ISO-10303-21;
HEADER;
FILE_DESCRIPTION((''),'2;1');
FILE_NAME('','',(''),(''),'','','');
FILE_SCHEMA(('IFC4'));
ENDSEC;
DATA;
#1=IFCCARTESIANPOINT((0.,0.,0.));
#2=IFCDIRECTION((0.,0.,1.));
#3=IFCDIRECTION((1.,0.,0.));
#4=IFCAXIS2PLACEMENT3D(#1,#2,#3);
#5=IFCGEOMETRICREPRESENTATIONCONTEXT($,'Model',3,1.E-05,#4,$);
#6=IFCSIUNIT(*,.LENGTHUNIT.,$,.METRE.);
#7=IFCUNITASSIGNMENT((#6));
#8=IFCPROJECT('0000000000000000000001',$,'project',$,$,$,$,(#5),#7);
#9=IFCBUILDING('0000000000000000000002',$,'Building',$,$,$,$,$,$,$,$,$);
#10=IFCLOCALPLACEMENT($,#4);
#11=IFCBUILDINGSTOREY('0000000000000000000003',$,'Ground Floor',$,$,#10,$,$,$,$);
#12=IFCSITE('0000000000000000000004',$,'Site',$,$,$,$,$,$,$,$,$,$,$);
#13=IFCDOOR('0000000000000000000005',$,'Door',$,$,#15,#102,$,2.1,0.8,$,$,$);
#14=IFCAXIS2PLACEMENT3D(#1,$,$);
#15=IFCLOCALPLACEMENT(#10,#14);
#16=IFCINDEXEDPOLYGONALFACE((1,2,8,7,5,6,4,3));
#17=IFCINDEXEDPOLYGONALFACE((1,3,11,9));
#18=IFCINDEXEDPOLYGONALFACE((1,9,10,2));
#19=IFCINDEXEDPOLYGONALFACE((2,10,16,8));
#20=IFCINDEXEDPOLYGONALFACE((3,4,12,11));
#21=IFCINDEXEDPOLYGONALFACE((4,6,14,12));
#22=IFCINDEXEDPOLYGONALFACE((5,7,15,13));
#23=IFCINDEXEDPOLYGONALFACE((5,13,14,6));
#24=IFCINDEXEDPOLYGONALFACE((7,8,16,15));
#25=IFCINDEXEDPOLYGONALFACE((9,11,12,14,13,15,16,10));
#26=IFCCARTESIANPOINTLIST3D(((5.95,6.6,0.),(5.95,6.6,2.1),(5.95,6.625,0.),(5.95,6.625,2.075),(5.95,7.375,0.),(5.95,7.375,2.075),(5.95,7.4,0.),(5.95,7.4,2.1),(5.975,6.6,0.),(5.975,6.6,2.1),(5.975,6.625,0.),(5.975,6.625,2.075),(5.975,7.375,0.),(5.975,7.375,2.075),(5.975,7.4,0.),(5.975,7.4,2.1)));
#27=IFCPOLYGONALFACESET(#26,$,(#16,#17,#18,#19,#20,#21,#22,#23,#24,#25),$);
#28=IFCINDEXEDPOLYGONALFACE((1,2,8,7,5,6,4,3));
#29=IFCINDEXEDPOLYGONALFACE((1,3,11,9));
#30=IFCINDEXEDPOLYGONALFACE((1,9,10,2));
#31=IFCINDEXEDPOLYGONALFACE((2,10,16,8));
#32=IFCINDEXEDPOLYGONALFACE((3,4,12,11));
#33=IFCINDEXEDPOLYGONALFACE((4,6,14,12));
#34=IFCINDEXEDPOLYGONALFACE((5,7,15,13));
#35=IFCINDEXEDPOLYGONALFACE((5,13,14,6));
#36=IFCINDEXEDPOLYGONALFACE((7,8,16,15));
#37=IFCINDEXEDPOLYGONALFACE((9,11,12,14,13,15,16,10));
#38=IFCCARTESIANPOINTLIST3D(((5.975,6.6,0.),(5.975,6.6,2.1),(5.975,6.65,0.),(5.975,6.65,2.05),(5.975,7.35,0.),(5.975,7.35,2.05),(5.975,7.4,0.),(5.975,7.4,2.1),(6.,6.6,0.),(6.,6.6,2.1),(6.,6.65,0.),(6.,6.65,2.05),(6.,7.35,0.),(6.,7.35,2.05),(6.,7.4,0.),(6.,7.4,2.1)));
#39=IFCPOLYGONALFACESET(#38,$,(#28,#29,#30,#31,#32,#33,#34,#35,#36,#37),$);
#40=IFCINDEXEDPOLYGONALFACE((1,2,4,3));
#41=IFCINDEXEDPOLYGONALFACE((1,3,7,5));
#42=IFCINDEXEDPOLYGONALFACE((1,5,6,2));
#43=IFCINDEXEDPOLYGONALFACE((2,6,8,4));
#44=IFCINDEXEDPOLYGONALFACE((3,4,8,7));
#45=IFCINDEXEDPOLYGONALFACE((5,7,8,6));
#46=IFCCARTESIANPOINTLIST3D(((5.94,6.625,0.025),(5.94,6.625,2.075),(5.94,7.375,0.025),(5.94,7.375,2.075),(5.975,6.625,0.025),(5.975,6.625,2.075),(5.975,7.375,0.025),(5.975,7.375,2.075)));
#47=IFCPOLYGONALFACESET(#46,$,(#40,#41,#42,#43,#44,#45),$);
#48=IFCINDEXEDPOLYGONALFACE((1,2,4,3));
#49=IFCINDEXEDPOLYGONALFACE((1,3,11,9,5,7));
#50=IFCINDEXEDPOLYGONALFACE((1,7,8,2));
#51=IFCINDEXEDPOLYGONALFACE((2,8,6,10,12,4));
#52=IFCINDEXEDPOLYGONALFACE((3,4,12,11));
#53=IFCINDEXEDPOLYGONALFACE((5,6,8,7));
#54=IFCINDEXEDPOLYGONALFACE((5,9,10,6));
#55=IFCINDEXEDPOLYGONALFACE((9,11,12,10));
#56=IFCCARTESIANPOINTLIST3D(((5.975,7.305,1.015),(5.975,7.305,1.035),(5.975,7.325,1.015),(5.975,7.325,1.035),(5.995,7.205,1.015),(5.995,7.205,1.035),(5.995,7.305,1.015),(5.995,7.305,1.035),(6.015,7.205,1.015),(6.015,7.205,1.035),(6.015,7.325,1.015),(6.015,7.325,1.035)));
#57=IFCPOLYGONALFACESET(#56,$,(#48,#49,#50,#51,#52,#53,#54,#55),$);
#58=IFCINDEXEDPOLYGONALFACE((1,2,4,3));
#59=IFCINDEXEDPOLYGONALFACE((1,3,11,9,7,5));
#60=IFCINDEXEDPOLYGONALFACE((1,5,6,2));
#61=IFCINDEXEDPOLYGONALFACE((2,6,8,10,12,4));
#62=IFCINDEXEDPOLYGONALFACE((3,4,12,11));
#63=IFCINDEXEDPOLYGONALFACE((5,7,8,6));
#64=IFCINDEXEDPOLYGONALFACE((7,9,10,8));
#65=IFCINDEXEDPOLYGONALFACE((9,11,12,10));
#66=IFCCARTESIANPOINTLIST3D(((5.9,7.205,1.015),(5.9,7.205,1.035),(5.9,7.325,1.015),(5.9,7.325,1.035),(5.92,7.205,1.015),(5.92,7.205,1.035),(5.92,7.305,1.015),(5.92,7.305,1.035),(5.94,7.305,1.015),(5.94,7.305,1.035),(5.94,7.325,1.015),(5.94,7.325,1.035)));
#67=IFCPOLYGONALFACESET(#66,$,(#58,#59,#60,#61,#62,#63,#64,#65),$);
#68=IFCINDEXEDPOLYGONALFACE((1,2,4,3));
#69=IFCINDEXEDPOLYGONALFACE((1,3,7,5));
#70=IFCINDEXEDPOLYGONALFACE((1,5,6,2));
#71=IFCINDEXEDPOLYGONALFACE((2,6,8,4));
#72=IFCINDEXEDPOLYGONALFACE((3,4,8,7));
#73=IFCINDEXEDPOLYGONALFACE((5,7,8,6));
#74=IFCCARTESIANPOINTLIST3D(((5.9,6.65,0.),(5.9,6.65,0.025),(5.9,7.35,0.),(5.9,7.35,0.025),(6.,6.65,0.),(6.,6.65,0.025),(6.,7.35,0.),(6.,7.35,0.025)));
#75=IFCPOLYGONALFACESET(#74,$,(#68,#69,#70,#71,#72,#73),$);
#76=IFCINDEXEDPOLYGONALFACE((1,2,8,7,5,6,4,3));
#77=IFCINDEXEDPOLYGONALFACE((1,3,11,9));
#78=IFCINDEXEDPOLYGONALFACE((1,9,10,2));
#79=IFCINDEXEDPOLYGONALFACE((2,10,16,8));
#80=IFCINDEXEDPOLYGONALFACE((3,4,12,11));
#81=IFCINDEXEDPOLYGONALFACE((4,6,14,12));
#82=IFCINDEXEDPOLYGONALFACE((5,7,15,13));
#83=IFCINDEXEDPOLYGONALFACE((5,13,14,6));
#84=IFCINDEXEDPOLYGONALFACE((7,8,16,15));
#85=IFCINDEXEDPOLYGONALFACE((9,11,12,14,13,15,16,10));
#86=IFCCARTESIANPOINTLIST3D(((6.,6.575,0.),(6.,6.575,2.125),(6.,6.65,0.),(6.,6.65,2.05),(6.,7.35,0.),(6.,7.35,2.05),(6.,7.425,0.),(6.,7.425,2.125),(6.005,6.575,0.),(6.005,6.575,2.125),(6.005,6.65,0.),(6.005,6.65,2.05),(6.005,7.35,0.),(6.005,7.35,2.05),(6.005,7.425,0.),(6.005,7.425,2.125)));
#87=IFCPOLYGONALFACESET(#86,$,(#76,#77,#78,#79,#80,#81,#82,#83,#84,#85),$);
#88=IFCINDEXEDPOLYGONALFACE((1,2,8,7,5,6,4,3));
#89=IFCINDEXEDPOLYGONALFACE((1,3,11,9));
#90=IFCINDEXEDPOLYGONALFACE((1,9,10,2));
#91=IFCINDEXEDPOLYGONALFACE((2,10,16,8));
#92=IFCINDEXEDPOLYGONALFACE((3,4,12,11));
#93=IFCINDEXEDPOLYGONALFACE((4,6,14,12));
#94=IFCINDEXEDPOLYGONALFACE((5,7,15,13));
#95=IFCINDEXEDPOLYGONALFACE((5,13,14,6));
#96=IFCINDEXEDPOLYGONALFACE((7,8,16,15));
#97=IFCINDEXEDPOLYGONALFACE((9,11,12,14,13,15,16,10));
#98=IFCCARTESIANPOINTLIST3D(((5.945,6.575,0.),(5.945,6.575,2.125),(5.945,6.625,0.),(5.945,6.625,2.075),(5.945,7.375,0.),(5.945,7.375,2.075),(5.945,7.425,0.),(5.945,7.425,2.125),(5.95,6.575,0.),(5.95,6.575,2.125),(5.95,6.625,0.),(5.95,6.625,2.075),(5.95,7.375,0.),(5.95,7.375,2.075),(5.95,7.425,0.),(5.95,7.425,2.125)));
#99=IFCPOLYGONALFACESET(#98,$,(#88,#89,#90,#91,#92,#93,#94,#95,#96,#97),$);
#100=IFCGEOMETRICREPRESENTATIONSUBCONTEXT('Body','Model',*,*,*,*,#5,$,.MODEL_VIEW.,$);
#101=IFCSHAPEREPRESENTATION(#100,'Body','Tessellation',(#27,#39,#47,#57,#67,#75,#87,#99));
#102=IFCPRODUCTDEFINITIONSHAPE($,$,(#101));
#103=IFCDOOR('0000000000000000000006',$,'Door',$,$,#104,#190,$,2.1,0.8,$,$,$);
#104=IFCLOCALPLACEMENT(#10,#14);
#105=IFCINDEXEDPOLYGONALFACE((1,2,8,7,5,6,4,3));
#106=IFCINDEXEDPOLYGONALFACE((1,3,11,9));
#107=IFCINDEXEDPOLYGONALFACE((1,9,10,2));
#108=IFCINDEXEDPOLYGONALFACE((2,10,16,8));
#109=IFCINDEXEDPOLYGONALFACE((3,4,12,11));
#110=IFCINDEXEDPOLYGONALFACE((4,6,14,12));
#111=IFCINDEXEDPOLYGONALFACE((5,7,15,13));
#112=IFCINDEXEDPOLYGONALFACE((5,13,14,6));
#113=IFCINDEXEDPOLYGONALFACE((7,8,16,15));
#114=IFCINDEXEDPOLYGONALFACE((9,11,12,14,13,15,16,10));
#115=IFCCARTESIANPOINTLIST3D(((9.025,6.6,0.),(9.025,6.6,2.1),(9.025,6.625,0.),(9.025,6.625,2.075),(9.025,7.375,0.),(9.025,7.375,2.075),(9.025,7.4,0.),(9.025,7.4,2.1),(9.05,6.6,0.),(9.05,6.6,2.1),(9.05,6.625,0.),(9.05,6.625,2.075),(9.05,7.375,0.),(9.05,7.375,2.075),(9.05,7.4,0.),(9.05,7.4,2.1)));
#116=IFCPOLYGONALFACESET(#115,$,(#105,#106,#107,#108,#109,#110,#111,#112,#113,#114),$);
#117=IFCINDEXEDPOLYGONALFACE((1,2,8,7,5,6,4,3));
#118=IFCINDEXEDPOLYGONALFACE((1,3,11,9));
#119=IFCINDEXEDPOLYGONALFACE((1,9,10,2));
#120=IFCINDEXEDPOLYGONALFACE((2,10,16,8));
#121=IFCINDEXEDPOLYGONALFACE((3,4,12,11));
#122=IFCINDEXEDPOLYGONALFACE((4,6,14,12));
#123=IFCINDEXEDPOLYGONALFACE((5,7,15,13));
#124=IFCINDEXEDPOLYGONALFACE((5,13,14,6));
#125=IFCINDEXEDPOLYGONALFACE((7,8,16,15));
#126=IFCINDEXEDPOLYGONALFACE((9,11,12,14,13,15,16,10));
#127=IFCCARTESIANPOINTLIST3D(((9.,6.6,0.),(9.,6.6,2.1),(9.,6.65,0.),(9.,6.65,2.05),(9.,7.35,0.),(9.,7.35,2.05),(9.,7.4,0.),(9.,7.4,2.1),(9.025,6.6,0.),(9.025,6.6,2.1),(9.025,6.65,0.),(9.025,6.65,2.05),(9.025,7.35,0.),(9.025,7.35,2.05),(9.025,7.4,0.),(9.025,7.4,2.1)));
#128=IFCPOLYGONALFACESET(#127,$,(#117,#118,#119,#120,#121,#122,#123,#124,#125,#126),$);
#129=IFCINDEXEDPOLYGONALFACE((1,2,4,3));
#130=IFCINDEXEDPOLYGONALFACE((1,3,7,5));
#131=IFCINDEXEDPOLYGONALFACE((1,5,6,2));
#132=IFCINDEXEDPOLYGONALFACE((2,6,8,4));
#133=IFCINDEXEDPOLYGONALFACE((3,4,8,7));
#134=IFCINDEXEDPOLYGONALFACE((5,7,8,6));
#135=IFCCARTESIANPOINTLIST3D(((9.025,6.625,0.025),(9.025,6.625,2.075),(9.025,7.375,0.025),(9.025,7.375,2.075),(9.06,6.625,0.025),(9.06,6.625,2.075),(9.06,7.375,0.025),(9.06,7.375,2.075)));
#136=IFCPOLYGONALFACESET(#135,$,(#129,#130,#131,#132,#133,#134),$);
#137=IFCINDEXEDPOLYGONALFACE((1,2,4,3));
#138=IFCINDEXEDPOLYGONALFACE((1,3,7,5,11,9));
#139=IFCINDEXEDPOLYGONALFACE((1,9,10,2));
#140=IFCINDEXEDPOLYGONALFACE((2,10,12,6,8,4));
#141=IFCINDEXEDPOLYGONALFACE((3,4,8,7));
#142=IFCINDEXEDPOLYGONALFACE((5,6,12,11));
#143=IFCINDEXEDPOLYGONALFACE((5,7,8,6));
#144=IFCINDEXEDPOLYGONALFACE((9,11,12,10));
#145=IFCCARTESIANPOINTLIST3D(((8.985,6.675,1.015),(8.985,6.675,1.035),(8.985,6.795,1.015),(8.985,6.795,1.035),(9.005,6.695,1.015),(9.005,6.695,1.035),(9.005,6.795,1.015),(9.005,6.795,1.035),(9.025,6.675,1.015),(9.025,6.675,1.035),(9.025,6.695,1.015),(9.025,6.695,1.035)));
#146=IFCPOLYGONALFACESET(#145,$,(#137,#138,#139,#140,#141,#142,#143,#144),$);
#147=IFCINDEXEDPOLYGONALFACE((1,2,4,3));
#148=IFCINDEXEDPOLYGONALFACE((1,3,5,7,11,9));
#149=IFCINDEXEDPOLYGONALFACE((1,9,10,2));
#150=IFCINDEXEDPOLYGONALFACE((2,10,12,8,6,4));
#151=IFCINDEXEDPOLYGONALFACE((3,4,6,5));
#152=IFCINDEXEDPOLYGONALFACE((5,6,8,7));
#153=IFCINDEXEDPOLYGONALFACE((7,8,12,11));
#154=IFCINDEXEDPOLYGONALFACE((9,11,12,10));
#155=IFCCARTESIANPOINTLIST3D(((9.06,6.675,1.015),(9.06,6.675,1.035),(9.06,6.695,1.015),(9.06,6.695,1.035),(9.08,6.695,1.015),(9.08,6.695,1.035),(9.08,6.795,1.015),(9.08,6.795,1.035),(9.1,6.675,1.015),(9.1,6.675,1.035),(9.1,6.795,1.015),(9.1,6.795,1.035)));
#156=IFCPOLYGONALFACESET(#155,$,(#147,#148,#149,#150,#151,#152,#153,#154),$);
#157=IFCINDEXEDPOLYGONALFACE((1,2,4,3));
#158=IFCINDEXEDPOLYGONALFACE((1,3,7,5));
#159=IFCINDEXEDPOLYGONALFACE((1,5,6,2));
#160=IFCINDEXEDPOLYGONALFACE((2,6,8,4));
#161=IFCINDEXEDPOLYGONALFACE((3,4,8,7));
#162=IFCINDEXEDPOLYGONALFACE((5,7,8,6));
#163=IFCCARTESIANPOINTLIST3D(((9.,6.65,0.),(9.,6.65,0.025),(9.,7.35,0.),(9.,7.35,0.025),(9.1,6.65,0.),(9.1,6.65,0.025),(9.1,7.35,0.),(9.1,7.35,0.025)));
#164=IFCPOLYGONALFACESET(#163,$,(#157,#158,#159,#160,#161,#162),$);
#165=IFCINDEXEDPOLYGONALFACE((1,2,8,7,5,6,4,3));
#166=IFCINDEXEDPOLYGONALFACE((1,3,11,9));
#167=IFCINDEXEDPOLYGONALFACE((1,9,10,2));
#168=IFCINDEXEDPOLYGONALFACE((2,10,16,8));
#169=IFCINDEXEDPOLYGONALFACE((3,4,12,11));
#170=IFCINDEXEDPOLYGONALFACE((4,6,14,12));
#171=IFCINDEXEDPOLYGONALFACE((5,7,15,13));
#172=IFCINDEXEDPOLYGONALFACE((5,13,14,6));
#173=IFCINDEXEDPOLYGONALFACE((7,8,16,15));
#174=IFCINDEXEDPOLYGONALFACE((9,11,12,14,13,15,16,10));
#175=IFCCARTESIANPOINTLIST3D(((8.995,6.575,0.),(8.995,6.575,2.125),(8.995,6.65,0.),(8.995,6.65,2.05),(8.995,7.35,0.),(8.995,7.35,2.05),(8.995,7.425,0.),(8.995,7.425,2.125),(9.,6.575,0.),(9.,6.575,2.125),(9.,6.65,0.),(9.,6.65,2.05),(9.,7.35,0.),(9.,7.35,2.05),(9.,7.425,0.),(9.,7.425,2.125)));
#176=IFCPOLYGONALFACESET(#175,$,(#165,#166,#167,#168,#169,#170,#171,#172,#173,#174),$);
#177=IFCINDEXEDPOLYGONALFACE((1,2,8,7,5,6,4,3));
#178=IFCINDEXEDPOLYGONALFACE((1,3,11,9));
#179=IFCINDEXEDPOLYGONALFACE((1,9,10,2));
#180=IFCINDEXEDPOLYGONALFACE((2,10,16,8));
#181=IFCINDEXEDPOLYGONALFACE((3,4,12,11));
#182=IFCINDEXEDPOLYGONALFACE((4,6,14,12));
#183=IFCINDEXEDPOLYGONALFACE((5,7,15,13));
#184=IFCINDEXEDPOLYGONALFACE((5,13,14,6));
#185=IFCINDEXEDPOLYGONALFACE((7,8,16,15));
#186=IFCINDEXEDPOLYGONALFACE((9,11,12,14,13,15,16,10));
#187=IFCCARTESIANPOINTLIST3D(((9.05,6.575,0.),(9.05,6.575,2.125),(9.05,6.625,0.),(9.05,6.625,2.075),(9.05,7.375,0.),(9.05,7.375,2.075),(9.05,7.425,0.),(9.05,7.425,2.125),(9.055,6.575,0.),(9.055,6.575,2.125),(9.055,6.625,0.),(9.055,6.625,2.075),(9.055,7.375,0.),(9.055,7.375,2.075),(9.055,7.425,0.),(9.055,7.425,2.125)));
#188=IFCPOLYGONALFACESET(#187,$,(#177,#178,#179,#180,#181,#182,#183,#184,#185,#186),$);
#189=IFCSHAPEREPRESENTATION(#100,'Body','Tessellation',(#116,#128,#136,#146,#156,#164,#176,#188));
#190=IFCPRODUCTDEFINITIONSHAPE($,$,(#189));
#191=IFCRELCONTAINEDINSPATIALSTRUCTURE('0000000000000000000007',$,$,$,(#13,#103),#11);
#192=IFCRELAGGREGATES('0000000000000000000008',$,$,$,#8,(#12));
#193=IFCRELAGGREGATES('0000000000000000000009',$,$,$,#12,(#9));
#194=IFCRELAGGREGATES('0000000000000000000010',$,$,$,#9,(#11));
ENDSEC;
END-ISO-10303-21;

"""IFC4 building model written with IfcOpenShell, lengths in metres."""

from ifc_helpers import new_model, si_unit, frame, origin_with_axes, place, context, subcontext, project, spatial, line, indexed_curve, outline, extrude, element, save


model = new_model("IFC4")

# Units and contexts
model_context = context("Model", 3, precision=1e-05, world=origin_with_axes())
body_context = subcontext(model_context, "Body", "Model", "MODEL_VIEW")
ifc_project = project(units=[si_unit("LENGTHUNIT", "METRE")], contexts=[model_context])

# Site, building, storey
site = spatial("IfcSite", under=ifc_project, Name="Site")
building = spatial("IfcBuilding", under=site, Name="Building")
storey_placement = place(None, origin_with_axes())
storey = spatial("IfcBuildingStorey", under=building, at=storey_placement, Name="Ground Floor")

# Doors
door_1_placement = place(storey_placement, frame((6.0, 6.6, 0.0), z_axis=(0.0, 0.0, 1.0), x_axis=(0.0, 1.0, 0.0)))
element("IfcDoor", 1, at=door_1_placement, inside=storey, Name="Door", OverallHeight=2.1, OverallWidth=0.8, context=body_context, shape_type="SweptSolid", body=[
    extrude(outline(indexed_curve([(0.0, 0.0), (0.0, 2.1), (0.8, 2.1), (0.8, 0.0), (0.775, 0.0), (0.775, 2.075), (0.025, 2.075), (0.025, 0.0)], segments=[line(1, 2, 3, 4, 5, 6, 7, 8, 1)])), frame((0.0, 0.025, 0.0), z_axis=(0.0, -1.0, 0.0), x_axis=(1.0, 0.0, 0.0)), (0.0, 0.0, -1.0), 0.025),
    extrude(outline(indexed_curve([(0.0, 0.0), (0.0, 2.1), (0.8, 2.1), (0.8, 0.0), (0.75, 0.0), (0.75, 2.05), (0.05, 2.05), (0.05, 0.0)], segments=[line(1, 2, 3, 4, 5, 6, 7, 8, 1)])), frame((0.0, 0.0, 0.0), z_axis=(0.0, -1.0, 0.0), x_axis=(1.0, 0.0, 0.0)), (0.0, 0.0, -1.0), 0.025),
    extrude(outline(indexed_curve([(0.0, 0.0), (0.75, 0.0), (0.75, 0.035), (0.0, 0.035)], segments=[line(1, 2, 3, 4, 1)])), frame((0.025, 0.025, 0.025), z_axis=(0.0, 0.0, 1.0), x_axis=(1.0, 0.0, 0.0)), (0.0, 0.0, 1.0), 2.05),
    extrude(outline(indexed_curve([(0.0, 0.0), (0.0, -0.04), (-0.12, -0.04), (-0.12, -0.02), (-0.02, -0.02), (-0.02, 0.0)], segments=[line(1, 2, 3, 4, 5, 6, 1)])), frame((0.725, 0.025, 1.015), z_axis=(0.0, 0.0, 1.0), x_axis=(1.0, 0.0, 0.0)), (0.0, 0.0, 1.0), 0.02),
    extrude(outline(indexed_curve([(0.0, 0.0), (0.0, 0.04), (-0.12, 0.04), (-0.12, 0.02), (-0.02, 0.02), (-0.02, 0.0)], segments=[line(1, 2, 3, 4, 5, 6, 1)])), frame((0.725, 0.06, 1.015), z_axis=(0.0, 0.0, 1.0), x_axis=(1.0, 0.0, 0.0)), (0.0, 0.0, 1.0), 0.02),
    extrude(outline(indexed_curve([(0.0, 0.0), (0.7, 0.0), (0.7, 0.1), (0.0, 0.1)], segments=[line(1, 2, 3, 4, 1)])), frame((0.05, 0.0, 0.0), z_axis=(0.0, 0.0, 1.0), x_axis=(1.0, 0.0, 0.0)), (0.0, 0.0, 1.0), 0.025),
    extrude(outline(indexed_curve([(0.0, 0.0), (0.0, 2.125), (0.85, 2.125), (0.85, 0.0), (0.775, 0.0), (0.775, 2.05), (0.075, 2.05), (0.075, 0.0)], segments=[line(1, 2, 3, 4, 5, 6, 7, 8, 1)])), frame((-0.025, -0.005, 0.0), z_axis=(0.0, -1.0, 0.0), x_axis=(1.0, 0.0, 0.0)), (0.0, 0.0, -1.0), 0.005),
    extrude(outline(indexed_curve([(0.0, 0.0), (0.0, 2.125), (0.85, 2.125), (0.85, 0.0), (0.8, 0.0), (0.8, 2.075), (0.05, 2.075), (0.05, 0.0)], segments=[line(1, 2, 3, 4, 5, 6, 7, 8, 1)])), frame((-0.025, 0.05, 0.0), z_axis=(0.0, -1.0, 0.0), x_axis=(1.0, 0.0, 0.0)), (0.0, 0.0, -1.0), 0.005),
])
door_2_placement = place(storey_placement, frame((9.0, 7.4, 0.0), z_axis=(0.0, 0.0, 1.0), x_axis=(0.0, -1.0, 0.0)))
element("IfcDoor", 2, at=door_2_placement, inside=storey, Name="Door", OverallHeight=2.1, OverallWidth=0.8, context=body_context, shape_type="SweptSolid", body=[
    extrude(outline(indexed_curve([(0.0, 0.0), (0.0, 2.1), (0.8, 2.1), (0.8, 0.0), (0.775, 0.0), (0.775, 2.075), (0.025, 2.075), (0.025, 0.0)], segments=[line(1, 2, 3, 4, 5, 6, 7, 8, 1)])), frame((0.0, 0.025, 0.0), z_axis=(0.0, -1.0, 0.0), x_axis=(1.0, 0.0, 0.0)), (0.0, 0.0, -1.0), 0.025),
    extrude(outline(indexed_curve([(0.0, 0.0), (0.0, 2.1), (0.8, 2.1), (0.8, 0.0), (0.75, 0.0), (0.75, 2.05), (0.05, 2.05), (0.05, 0.0)], segments=[line(1, 2, 3, 4, 5, 6, 7, 8, 1)])), frame((0.0, 0.0, 0.0), z_axis=(0.0, -1.0, 0.0), x_axis=(1.0, 0.0, 0.0)), (0.0, 0.0, -1.0), 0.025),
    extrude(outline(indexed_curve([(0.0, 0.0), (0.75, 0.0), (0.75, 0.035), (0.0, 0.035)], segments=[line(1, 2, 3, 4, 1)])), frame((0.025, 0.025, 0.025), z_axis=(0.0, 0.0, 1.0), x_axis=(1.0, 0.0, 0.0)), (0.0, 0.0, 1.0), 2.05),
    extrude(outline(indexed_curve([(0.0, 0.0), (0.0, -0.04), (-0.12, -0.04), (-0.12, -0.02), (-0.02, -0.02), (-0.02, 0.0)], segments=[line(1, 2, 3, 4, 5, 6, 1)])), frame((0.725, 0.025, 1.015), z_axis=(0.0, 0.0, 1.0), x_axis=(1.0, 0.0, 0.0)), (0.0, 0.0, 1.0), 0.02),
    extrude(outline(indexed_curve([(0.0, 0.0), (0.0, 0.04), (-0.12, 0.04), (-0.12, 0.02), (-0.02, 0.02), (-0.02, 0.0)], segments=[line(1, 2, 3, 4, 5, 6, 1)])), frame((0.725, 0.06, 1.015), z_axis=(0.0, 0.0, 1.0), x_axis=(1.0, 0.0, 0.0)), (0.0, 0.0, 1.0), 0.02),
    extrude(outline(indexed_curve([(0.0, 0.0), (0.7, 0.0), (0.7, 0.1), (0.0, 0.1)], segments=[line(1, 2, 3, 4, 1)])), frame((0.05, 0.0, 0.0), z_axis=(0.0, 0.0, 1.0), x_axis=(1.0, 0.0, 0.0)), (0.0, 0.0, 1.0), 0.025),
    extrude(outline(indexed_curve([(0.0, 0.0), (0.0, 2.125), (0.85, 2.125), (0.85, 0.0), (0.775, 0.0), (0.775, 2.05), (0.075, 2.05), (0.075, 0.0)], segments=[line(1, 2, 3, 4, 5, 6, 7, 8, 1)])), frame((-0.025, -0.005, 0.0), z_axis=(0.0, -1.0, 0.0), x_axis=(1.0, 0.0, 0.0)), (0.0, 0.0, -1.0), 0.005),
    extrude(outline(indexed_curve([(0.0, 0.0), (0.0, 2.125), (0.85, 2.125), (0.85, 0.0), (0.8, 0.0), (0.8, 2.075), (0.05, 2.075), (0.05, 0.0)], segments=[line(1, 2, 3, 4, 5, 6, 7, 8, 1)])), frame((-0.025, 0.05, 0.0), z_axis=(0.0, -1.0, 0.0), x_axis=(1.0, 0.0, 0.0)), (0.0, 0.0, -1.0), 0.005),
])

save(model, "model.ifc")
